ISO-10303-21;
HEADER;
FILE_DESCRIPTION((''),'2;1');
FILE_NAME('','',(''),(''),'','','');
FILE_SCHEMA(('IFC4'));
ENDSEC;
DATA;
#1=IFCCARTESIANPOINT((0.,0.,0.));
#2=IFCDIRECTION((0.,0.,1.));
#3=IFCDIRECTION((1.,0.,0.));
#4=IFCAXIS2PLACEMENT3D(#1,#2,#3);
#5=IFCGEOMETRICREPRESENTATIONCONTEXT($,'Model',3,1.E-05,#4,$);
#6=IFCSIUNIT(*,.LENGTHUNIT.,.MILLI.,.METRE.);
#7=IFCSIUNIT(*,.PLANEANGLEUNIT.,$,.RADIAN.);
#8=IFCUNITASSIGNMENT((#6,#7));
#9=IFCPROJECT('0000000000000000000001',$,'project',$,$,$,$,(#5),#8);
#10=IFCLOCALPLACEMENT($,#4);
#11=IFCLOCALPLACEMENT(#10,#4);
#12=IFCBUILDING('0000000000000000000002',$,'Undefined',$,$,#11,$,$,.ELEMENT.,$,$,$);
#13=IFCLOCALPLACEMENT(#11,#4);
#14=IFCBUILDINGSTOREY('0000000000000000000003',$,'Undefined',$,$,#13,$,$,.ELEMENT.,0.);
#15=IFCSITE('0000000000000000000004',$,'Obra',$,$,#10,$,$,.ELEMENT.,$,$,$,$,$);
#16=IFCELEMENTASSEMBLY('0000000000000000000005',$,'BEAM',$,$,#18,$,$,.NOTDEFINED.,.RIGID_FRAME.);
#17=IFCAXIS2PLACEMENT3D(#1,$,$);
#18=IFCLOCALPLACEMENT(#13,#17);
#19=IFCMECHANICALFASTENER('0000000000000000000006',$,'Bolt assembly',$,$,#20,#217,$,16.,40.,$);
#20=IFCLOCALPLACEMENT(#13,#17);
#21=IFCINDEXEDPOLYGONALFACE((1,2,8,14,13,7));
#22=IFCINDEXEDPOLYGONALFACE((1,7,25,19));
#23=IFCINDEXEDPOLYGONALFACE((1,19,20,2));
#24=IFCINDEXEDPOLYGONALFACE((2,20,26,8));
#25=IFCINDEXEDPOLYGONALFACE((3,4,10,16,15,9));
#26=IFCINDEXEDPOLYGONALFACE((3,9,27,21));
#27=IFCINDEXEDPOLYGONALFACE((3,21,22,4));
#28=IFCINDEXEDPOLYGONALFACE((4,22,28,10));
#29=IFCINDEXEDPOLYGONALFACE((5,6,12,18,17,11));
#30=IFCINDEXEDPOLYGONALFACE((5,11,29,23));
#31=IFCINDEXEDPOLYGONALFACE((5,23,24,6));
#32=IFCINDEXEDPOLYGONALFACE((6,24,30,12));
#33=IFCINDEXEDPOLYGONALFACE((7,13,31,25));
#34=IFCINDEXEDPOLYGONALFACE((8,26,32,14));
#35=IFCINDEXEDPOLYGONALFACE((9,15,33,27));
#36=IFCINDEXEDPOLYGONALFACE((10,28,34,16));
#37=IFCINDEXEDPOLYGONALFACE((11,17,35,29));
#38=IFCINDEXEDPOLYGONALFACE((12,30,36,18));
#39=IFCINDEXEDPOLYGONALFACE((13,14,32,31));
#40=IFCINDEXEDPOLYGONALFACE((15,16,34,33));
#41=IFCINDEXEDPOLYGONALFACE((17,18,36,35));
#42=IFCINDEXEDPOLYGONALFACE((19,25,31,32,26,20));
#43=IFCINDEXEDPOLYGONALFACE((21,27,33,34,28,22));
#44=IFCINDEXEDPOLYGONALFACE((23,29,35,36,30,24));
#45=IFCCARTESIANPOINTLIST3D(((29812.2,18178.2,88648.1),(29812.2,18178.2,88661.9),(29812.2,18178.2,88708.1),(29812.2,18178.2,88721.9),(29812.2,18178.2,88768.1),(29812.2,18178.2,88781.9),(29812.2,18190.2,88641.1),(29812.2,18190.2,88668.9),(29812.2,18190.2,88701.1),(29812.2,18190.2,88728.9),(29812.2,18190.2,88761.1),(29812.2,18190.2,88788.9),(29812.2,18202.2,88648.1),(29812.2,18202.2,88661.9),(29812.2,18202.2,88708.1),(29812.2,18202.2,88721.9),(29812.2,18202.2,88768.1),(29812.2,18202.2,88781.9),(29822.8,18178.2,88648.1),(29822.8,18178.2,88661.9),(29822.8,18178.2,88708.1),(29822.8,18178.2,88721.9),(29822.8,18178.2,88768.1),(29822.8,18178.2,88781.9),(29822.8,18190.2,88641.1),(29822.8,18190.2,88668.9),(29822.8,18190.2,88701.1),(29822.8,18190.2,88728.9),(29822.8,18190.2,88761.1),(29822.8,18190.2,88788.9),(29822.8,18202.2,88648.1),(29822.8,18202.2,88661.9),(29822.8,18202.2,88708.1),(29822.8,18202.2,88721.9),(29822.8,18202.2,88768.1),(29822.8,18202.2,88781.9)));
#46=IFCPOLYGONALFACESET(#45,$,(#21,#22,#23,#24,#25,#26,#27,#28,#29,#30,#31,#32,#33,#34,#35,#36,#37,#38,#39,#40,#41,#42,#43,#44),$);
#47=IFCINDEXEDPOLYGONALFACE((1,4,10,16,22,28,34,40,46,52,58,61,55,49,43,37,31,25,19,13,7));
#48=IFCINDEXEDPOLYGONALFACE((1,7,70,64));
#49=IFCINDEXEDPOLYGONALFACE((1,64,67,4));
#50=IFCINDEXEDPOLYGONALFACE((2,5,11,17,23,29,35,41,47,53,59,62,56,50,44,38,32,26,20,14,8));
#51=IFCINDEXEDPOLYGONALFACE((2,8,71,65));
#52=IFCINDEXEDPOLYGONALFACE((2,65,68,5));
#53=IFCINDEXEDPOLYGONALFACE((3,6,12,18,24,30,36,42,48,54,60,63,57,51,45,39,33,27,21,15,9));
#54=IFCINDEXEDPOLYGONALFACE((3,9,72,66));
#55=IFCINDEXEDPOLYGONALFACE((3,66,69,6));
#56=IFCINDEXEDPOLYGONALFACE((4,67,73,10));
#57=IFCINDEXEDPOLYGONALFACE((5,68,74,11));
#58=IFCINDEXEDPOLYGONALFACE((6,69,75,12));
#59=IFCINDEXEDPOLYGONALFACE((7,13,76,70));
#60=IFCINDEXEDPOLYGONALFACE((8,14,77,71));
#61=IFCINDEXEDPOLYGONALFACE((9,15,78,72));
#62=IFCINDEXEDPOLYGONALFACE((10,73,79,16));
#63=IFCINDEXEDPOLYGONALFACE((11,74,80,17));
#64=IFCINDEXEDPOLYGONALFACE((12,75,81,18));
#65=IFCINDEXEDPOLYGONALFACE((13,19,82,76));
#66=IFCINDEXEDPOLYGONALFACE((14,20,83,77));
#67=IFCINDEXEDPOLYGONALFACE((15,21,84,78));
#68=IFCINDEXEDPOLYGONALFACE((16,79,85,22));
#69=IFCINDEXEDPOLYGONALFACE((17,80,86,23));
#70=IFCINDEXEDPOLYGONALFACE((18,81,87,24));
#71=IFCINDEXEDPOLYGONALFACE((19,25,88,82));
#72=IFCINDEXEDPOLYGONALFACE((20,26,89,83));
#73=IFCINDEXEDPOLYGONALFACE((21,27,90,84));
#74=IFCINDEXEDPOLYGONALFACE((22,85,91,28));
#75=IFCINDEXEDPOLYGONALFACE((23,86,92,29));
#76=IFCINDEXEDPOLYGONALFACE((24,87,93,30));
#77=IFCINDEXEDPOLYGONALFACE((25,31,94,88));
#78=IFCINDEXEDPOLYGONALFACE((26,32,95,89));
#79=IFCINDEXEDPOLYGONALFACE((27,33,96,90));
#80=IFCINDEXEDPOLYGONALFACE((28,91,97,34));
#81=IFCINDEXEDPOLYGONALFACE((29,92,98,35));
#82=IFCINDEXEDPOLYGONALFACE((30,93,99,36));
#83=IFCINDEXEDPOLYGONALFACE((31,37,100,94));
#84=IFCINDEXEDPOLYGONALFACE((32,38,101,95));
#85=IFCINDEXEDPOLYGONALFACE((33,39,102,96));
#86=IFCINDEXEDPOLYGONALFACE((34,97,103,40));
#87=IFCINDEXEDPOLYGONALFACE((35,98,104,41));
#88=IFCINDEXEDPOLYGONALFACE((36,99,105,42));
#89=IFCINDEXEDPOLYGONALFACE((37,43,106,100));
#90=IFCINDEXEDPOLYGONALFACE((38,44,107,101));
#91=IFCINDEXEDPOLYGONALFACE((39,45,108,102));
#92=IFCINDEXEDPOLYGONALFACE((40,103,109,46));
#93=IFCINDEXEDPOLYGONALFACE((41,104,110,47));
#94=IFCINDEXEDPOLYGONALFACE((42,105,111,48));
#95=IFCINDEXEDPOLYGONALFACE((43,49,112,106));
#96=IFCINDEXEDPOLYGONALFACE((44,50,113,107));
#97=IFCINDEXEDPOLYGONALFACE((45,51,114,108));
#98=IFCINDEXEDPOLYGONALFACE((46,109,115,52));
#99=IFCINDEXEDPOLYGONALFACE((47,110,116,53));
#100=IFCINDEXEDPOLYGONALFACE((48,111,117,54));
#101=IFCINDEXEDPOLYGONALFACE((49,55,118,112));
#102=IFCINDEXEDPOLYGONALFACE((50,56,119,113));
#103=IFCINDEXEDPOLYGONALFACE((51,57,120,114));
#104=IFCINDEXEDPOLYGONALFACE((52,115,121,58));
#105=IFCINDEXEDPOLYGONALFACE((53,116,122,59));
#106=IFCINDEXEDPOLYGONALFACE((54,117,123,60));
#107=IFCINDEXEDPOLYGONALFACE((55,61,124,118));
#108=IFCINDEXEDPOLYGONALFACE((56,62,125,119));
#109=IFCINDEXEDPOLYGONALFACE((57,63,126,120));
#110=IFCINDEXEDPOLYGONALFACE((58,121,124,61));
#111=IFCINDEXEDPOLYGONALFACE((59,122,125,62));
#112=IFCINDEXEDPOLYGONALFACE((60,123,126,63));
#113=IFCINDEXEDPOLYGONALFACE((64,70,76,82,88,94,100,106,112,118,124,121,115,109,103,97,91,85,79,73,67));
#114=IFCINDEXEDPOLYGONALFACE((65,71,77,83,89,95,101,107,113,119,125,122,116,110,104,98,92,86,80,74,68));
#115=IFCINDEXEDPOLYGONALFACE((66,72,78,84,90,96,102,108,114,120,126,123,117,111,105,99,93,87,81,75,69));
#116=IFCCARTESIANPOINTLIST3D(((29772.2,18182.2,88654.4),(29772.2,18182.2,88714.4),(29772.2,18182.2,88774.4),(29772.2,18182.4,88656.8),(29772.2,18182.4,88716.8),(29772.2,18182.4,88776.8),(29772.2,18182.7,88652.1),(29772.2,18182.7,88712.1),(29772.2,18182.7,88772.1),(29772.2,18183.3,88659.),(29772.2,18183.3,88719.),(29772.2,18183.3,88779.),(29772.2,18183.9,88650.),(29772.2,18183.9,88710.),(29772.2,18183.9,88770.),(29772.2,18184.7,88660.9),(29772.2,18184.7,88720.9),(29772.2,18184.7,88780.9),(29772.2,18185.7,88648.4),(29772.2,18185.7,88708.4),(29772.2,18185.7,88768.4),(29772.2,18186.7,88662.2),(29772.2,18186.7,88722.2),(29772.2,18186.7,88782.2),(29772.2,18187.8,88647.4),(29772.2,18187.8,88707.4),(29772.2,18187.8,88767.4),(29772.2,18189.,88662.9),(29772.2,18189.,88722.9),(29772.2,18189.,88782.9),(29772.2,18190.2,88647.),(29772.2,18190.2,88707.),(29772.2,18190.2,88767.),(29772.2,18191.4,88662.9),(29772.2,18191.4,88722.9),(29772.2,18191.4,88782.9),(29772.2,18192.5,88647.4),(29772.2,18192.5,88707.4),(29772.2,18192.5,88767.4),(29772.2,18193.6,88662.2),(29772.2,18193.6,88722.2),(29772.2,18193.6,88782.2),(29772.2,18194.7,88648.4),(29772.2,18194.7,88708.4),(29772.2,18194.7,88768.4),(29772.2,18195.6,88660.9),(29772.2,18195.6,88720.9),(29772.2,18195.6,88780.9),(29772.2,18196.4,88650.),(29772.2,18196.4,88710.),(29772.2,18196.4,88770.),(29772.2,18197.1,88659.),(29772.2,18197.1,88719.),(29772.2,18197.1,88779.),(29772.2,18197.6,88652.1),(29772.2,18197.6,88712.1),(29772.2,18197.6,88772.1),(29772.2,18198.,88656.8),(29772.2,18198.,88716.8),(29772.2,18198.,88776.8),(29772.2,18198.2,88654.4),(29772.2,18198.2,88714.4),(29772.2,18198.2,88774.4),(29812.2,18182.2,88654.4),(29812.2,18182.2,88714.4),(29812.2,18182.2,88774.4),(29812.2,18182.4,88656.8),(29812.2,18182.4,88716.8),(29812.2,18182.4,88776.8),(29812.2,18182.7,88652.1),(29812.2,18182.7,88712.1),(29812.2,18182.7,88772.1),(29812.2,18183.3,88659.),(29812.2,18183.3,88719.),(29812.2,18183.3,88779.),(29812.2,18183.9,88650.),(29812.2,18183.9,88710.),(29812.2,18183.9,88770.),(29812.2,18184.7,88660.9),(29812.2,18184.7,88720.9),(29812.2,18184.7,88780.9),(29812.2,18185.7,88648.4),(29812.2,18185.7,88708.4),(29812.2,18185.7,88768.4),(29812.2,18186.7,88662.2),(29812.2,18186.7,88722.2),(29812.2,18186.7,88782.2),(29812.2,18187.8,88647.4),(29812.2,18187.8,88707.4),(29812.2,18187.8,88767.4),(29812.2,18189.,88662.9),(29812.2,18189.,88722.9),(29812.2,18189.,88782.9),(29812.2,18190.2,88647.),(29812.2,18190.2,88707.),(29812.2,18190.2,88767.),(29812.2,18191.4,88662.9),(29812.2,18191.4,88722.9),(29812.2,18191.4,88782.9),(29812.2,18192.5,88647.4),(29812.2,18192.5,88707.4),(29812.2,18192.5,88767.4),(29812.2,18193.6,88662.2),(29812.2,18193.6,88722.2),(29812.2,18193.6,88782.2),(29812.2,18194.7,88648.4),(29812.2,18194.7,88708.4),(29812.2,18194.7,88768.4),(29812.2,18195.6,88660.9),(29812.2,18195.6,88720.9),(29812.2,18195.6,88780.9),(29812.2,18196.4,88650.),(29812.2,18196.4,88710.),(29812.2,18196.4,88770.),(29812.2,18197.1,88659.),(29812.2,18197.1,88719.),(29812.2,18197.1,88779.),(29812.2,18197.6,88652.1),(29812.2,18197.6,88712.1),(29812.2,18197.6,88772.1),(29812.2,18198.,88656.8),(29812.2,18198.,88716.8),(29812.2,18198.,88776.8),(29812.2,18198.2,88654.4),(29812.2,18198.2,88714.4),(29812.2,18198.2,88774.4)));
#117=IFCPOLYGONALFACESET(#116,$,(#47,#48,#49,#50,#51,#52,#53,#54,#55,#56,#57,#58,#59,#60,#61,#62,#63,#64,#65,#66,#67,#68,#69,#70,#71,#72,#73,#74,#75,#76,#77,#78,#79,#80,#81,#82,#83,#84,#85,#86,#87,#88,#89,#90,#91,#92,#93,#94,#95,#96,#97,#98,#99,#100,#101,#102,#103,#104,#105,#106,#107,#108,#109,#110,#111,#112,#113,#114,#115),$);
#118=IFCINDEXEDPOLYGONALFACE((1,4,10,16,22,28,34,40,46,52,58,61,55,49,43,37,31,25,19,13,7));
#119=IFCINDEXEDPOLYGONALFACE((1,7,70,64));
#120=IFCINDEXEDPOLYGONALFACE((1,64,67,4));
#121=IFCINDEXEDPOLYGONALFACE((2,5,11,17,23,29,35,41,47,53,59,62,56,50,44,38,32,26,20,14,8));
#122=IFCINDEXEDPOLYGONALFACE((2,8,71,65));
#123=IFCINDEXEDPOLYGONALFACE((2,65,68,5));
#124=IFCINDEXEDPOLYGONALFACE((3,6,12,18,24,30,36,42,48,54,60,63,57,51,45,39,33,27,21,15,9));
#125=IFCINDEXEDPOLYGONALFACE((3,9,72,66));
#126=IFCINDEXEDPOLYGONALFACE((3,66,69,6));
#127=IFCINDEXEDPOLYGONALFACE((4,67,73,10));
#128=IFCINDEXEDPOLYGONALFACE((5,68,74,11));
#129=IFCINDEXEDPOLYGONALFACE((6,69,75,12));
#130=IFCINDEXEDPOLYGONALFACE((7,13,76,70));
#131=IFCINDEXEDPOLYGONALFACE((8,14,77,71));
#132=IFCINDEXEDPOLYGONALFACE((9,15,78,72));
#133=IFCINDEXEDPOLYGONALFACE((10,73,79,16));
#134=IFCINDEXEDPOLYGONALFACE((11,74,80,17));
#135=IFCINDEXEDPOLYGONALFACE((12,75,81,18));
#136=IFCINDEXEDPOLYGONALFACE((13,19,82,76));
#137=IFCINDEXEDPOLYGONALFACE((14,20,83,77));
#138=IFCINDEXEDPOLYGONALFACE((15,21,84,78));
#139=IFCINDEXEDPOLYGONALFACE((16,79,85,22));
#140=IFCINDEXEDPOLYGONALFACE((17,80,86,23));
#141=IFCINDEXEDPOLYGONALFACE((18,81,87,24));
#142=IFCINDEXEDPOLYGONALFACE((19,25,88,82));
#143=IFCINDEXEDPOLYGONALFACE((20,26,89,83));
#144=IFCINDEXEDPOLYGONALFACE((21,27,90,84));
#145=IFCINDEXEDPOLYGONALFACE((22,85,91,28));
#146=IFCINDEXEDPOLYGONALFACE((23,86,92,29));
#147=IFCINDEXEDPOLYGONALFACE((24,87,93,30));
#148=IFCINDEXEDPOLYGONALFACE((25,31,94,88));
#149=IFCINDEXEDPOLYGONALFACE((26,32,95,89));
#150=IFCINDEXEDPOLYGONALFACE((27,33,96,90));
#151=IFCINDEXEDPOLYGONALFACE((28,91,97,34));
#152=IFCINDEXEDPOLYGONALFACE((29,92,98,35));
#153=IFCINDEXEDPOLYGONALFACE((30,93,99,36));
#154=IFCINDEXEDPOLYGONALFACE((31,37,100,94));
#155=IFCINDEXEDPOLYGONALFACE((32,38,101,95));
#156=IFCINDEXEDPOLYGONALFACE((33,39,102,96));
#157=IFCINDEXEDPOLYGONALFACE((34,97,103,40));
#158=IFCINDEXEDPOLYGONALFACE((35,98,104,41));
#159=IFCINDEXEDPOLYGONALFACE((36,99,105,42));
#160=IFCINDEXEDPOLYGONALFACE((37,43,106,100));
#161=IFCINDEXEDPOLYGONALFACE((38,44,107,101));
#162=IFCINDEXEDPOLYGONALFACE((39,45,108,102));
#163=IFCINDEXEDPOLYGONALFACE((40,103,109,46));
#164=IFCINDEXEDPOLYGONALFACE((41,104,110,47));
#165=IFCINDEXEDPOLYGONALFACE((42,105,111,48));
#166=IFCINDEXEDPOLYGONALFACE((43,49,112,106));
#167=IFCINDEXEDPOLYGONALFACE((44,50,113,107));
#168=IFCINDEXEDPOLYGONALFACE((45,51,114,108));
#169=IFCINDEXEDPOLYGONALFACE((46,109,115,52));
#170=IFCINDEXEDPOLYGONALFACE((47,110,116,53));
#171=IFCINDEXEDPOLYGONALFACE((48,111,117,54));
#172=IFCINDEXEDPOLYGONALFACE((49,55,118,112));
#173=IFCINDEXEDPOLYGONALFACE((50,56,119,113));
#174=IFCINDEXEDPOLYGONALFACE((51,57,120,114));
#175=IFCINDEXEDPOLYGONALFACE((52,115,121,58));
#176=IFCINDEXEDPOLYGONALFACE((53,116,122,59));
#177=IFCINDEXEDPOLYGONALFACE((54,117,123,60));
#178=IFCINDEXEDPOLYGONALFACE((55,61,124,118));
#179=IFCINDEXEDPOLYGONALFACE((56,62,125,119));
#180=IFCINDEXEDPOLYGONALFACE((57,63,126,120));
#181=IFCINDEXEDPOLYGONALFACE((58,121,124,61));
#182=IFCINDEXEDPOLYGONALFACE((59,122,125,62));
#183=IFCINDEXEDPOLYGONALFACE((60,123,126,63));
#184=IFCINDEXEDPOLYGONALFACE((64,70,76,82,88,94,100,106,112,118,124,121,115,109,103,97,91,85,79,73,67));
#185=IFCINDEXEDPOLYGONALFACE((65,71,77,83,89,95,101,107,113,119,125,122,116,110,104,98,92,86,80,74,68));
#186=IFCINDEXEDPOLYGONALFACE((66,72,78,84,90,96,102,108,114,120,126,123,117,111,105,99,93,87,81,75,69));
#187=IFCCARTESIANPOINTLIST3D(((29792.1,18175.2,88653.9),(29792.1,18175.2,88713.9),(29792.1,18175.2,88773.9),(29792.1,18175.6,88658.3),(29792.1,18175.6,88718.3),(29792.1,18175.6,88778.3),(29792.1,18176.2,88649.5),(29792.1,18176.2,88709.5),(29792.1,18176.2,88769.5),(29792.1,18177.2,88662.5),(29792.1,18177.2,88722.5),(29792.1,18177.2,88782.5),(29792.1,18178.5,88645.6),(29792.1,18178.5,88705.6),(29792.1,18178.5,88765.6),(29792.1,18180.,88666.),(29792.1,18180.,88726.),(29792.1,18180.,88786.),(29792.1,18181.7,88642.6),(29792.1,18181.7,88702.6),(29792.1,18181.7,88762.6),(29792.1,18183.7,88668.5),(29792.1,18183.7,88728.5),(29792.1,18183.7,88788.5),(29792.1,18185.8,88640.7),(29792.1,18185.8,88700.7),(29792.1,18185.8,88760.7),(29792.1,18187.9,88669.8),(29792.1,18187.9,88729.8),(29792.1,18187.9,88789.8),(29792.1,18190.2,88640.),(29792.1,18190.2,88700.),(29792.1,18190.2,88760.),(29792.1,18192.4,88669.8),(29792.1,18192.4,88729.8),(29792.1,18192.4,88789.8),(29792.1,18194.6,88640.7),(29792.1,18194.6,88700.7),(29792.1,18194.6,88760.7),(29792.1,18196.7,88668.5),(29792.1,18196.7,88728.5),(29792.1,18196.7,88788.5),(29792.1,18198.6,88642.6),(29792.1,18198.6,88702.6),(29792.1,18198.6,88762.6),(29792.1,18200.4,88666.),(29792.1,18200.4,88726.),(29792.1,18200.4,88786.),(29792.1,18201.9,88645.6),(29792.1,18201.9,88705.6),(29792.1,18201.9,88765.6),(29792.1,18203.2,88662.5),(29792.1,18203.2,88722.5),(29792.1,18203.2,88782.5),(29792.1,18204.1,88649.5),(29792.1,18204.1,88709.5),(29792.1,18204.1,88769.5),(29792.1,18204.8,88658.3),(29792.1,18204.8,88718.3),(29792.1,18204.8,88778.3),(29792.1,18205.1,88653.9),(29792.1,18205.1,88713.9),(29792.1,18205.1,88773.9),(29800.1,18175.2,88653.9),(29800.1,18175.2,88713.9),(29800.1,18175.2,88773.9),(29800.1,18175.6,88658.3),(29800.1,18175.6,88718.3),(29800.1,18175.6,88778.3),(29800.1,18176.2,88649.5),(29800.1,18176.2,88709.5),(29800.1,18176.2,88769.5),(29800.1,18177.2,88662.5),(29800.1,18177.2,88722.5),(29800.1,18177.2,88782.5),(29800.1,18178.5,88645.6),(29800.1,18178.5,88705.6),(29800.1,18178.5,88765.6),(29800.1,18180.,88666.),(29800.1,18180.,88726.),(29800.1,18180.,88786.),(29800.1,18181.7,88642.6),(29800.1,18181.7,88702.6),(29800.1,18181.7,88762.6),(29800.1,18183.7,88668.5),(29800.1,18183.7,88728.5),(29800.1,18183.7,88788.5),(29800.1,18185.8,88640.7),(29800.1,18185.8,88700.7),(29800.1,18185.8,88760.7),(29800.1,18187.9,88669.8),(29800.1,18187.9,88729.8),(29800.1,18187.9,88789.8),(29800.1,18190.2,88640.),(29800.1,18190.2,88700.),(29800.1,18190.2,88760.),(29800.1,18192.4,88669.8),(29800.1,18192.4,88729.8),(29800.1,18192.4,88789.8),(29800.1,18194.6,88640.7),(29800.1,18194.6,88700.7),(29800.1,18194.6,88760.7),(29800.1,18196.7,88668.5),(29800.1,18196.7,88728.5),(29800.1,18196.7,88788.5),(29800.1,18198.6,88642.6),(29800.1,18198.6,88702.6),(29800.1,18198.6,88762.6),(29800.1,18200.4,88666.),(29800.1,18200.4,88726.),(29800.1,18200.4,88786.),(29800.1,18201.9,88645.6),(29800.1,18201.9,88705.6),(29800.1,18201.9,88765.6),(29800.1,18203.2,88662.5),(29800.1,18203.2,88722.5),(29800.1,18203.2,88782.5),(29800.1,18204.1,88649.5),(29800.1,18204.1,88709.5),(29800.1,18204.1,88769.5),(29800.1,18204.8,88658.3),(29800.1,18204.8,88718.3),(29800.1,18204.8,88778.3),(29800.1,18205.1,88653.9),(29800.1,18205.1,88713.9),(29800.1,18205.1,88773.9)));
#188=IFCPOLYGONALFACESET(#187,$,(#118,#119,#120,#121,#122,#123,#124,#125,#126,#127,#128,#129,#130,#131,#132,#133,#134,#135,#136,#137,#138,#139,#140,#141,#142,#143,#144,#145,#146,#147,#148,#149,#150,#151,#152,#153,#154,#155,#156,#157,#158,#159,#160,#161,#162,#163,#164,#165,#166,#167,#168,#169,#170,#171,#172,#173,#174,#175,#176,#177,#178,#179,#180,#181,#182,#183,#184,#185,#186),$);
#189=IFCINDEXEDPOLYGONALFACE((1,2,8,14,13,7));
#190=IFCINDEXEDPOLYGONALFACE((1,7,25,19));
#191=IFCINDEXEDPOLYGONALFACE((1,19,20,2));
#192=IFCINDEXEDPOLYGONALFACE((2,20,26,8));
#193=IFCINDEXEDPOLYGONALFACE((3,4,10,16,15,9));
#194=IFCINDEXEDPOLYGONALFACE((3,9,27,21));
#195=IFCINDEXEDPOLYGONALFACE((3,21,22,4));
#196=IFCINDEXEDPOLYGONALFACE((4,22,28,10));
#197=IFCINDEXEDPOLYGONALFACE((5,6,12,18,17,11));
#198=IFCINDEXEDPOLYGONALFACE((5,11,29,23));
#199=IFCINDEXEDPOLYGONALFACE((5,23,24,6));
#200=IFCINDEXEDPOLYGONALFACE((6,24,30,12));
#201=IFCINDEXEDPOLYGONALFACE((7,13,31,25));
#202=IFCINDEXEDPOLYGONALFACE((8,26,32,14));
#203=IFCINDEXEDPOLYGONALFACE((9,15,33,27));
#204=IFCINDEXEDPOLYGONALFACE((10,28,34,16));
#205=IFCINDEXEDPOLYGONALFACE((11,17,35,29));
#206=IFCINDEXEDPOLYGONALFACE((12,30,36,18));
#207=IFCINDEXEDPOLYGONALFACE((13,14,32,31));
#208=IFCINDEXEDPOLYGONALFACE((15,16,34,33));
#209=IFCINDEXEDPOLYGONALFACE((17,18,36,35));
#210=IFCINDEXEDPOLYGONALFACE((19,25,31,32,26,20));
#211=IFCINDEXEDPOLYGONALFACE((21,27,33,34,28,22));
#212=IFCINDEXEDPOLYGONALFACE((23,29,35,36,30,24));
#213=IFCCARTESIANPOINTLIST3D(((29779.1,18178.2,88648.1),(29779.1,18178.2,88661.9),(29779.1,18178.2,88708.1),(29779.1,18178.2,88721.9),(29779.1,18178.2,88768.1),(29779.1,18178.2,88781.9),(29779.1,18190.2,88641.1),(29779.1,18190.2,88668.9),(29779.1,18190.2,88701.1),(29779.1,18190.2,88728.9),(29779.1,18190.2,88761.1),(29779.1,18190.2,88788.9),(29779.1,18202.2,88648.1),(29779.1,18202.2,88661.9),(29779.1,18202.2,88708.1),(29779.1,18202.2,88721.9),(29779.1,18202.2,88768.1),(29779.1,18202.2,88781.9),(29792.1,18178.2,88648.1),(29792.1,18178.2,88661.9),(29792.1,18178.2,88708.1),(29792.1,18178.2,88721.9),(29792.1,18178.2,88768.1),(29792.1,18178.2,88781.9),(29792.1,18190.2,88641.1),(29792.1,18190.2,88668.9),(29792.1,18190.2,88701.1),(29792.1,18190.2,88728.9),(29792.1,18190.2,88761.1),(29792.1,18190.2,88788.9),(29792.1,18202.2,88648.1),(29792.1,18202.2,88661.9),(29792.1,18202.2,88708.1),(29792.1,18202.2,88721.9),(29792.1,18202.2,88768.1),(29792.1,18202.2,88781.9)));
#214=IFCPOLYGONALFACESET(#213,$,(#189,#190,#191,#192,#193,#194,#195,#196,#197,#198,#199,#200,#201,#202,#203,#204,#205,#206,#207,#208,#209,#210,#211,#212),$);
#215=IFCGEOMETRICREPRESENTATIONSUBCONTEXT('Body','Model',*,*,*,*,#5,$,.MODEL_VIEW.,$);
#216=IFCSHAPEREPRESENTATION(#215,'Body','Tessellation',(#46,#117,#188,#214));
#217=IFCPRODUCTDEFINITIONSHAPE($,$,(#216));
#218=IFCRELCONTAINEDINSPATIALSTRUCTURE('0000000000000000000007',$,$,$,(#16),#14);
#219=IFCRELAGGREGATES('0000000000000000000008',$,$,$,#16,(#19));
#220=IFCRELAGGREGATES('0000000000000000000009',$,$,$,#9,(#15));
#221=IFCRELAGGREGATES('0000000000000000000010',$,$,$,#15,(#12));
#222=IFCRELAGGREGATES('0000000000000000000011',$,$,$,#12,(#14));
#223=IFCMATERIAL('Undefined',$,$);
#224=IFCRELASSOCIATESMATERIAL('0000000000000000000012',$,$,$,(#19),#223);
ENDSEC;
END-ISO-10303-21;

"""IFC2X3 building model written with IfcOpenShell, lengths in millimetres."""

from ifc_helpers import new_model, si_unit, frame, origin_with_axes, origin_2d_with_axis, place, context, subcontext, project, spatial, polyline, circle, outline, extrude, source, transform, mapped, material, element, aggregate, save


model = new_model("IFC2X3")

# Units and contexts
model_context = context("Model", 3, precision=1e-05, world=origin_with_axes())
body_context = subcontext(model_context, "Body", "Model", "MODEL_VIEW")
ifc_project = project(units=[si_unit("LENGTHUNIT", "METRE", prefix="MILLI"), si_unit("PLANEANGLEUNIT", "RADIAN")], contexts=[model_context])

# Site, building, storey
site_placement = place(None, origin_with_axes())
site = spatial("IfcSite", under=ifc_project, at=site_placement, Name="Obra", CompositionType="ELEMENT")
building_placement = place(site_placement, origin_with_axes())
building = spatial("IfcBuilding", under=site, at=building_placement, Name="Undefined", CompositionType="ELEMENT")
storey_placement = place(building_placement, origin_with_axes())
storey = spatial("IfcBuildingStorey", under=building, at=storey_placement, Name="Undefined", CompositionType="ELEMENT", Elevation=0.0)

# Shared definitions
ifc_material_1 = material(Name="Undefined")

# Element assembly, mechanical fastener
shared_shape_1 = source(origin_with_axes(), body_context, "Body", "SweptSolid", [
    extrude(outline(polyline([(13.9, 0.0), (6.9, 12.0), (-6.9, 12.0), (-13.9, 0.0), (-6.9, -12.0), (6.9, -12.0), (13.9, 0.0)])), frame((0.0, -19.7, 0.0), z_axis=(0.0, 1.0, 0.0), x_axis=(1.0, 0.0, 0.0)), (0.0, 0.0, 1.0), 10.6),
    extrude(circle(Radius=8.0, at=origin_2d_with_axis()), frame((0.0, -9.1, 0.0), z_axis=(0.0, 1.0, 0.0), x_axis=(1.0, 0.0, 0.0)), (0.0, 0.0, 1.0), 40.0),
    extrude(circle(Radius=15.0, at=origin_2d_with_axis()), frame((0.0, 3.0, 0.0), z_axis=(0.0, 1.0, 0.0), x_axis=(1.0, 0.0, 0.0)), (0.0, 0.0, 1.0), 8.0),
    extrude(outline(polyline([(13.9, 0.0), (6.9, 12.0), (-6.9, 12.0), (-13.9, 0.0), (-6.9, -12.0), (6.9, -12.0), (13.9, 0.0)])), frame((0.0, 11.0, 0.0), z_axis=(0.0, 1.0, 0.0), x_axis=(1.0, 0.0, 0.0)), (0.0, 0.0, 1.0), 13.0),
])
assembly_1_placement = place(storey_placement, origin_with_axes())
assembly_1 = element("IfcElementAssembly", 1, at=assembly_1_placement, inside=storey, Name="BEAM", AssemblyPlace="NOTDEFINED", PredefinedType="RIGID_FRAME")
mechanical_fastener_1_placement = place(assembly_1_placement, frame((29803.1, 18140.2, 88835.0), z_axis=(-0.000002, 1.0, 0.0), x_axis=(0.0, 0.0, -1.0)))
mechanical_fastener_1 = element("IfcMechanicalFastener", 2, at=mechanical_fastener_1_placement, material=ifc_material_1, Name="Bolt assembly", NominalDiameter=16.0, NominalLength=40.0, context=body_context, shape_type="MappedRepresentation", body=[
    mapped(shared_shape_1, transform((60.0, 0.0, 50.0))),
    mapped(shared_shape_1, transform((120.0, 0.0, 50.0))),
    mapped(shared_shape_1, transform((180.0, 0.0, 50.0))),
])

aggregate(assembly_1, [mechanical_fastener_1])

save(model, "model.ifc")
